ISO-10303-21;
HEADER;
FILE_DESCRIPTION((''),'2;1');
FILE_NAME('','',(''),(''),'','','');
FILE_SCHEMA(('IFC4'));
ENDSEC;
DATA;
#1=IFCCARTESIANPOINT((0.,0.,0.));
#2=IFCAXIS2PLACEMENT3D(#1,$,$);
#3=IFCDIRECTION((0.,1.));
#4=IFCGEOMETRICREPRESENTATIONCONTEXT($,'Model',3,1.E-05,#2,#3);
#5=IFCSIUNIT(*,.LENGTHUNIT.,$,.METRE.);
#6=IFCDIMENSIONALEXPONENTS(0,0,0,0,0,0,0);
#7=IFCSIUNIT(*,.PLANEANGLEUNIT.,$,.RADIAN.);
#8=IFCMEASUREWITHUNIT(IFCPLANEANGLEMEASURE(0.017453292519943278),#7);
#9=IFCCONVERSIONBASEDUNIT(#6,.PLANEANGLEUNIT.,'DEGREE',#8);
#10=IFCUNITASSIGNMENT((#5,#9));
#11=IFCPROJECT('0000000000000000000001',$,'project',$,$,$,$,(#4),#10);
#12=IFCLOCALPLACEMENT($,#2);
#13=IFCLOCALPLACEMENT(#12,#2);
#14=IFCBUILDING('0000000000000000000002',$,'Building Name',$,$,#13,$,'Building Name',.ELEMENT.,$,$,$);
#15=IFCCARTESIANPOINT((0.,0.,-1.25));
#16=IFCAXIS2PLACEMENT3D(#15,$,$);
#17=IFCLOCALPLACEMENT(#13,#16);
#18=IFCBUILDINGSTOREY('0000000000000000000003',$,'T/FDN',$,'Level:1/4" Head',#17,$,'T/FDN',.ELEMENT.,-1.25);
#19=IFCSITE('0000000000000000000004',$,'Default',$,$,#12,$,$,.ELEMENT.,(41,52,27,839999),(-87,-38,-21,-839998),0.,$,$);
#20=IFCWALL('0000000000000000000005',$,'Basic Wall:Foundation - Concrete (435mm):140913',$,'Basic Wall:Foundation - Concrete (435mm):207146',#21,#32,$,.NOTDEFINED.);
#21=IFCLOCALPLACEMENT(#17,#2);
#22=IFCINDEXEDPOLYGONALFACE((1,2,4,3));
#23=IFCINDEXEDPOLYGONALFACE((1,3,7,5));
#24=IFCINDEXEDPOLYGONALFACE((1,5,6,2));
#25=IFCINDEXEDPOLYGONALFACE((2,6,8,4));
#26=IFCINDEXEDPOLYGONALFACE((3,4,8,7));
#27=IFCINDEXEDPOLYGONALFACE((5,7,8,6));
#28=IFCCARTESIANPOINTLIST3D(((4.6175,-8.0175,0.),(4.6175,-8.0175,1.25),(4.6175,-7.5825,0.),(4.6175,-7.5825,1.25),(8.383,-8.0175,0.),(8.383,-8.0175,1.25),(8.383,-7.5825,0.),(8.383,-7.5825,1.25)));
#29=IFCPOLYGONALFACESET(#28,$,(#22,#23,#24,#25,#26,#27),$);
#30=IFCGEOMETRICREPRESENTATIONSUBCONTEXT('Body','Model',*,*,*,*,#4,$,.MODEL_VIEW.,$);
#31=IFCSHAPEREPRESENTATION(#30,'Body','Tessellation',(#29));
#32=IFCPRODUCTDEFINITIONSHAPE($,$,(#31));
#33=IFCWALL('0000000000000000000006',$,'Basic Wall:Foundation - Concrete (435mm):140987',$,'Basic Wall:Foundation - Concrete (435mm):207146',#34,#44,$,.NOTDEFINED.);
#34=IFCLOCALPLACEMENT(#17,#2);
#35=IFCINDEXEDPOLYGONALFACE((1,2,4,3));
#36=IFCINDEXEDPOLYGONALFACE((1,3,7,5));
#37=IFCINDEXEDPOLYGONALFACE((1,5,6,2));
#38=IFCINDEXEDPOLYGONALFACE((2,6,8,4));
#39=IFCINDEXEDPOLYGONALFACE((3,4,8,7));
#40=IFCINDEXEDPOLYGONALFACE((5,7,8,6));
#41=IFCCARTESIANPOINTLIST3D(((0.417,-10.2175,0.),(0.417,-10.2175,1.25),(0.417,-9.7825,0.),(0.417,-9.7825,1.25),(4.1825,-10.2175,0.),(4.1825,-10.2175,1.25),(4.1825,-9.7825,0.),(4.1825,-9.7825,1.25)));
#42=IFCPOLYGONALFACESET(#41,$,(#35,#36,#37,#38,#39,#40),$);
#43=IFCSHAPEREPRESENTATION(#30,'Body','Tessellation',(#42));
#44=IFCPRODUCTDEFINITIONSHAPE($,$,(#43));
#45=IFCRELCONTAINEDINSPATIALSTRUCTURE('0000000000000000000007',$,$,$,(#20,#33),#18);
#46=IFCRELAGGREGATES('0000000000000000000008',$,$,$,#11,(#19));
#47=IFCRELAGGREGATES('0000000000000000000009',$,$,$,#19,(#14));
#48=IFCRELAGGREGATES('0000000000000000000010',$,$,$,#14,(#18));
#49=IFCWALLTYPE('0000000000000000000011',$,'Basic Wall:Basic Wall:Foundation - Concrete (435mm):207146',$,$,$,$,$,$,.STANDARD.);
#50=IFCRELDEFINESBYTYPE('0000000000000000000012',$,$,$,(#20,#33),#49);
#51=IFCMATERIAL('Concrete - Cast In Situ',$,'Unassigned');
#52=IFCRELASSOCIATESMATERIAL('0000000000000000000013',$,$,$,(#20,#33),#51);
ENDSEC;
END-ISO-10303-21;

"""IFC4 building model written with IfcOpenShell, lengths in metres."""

from ifc_helpers import new_model, entity, si_unit, converted_unit, direction, frame, origin, place, context, subcontext, project, spatial, indexed_curve, outline, extrude, material, type_object, element, save


model = new_model("IFC4")

# Units and contexts
model_context = context("Model", 3, precision=1e-05, world=origin(), true_north=direction((0.0, 1.0)))
body_context = subcontext(model_context, "Body", "Model", "MODEL_VIEW")
ifc_project = project(units=[si_unit("LENGTHUNIT", "METRE"), converted_unit("PLANEANGLEUNIT", "DEGREE", entity("IfcPlaneAngleMeasure", 0.017453292519943278), si_unit("PLANEANGLEUNIT", "RADIAN"), dimensions=[0, 0, 0, 0, 0, 0, 0])], contexts=[model_context])

# Site, building, storey
site_placement = place(None, origin())
site = spatial("IfcSite", under=ifc_project, at=site_placement, Name="Default", CompositionType="ELEMENT", RefLatitude=(41, 52, 27, 839999), RefLongitude=(-87, -38, -21, -839998), RefElevation=0.0)
building_placement = place(site_placement, origin())
building = spatial("IfcBuilding", under=site, at=building_placement, Name="Building Name", LongName="Building Name", CompositionType="ELEMENT")
storey_placement = place(building_placement, frame((0.0, 0.0, -1.25)))
storey = spatial("IfcBuildingStorey", under=building, at=storey_placement, Name="T/FDN", ObjectType="Level:1/4\" Head", LongName="T/FDN", CompositionType="ELEMENT", Elevation=-1.25)

# Shared definitions
ifc_material = material(Name="Concrete - Cast In Situ", Category="Unassigned")

# Walls
wall_type_1 = type_object("IfcWallType", Name="Basic Wall:Basic Wall:Foundation - Concrete (435mm):207146", PredefinedType="STANDARD")
wall_1_placement = place(storey_placement, frame((8.383, -7.8, 0.0), z_axis=(0.0, 0.0, 1.0), x_axis=(-1.0, 0.0, 0.0)))
element("IfcWall", 1, at=wall_1_placement, inside=storey, type_object=wall_type_1, material=ifc_material, Name="Basic Wall:Foundation - Concrete (435mm):140913", ObjectType="Basic Wall:Foundation - Concrete (435mm):207146", PredefinedType="NOTDEFINED", context=body_context, shape_type="SweptSolid", body=[
    extrude(outline(indexed_curve([(3.7655, 0.2175), (0.0, 0.2175), (0.0, -0.2175), (3.7655, -0.2175), (3.7655, 0.2175)], self_intersect=False)), origin(), (0.0, 0.0, 1.0), 1.25),
])
wall_2_placement = place(storey_placement, frame((0.417, -10.0, 0.0)))
element("IfcWall", 2, at=wall_2_placement, inside=storey, type_object=wall_type_1, material=ifc_material, Name="Basic Wall:Foundation - Concrete (435mm):140987", ObjectType="Basic Wall:Foundation - Concrete (435mm):207146", PredefinedType="NOTDEFINED", context=body_context, shape_type="SweptSolid", body=[
    extrude(outline(indexed_curve([(3.7655, 0.2175), (0.0, 0.2175), (0.0, -0.2175), (3.7655, -0.2175), (3.7655, 0.2175)], self_intersect=False)), origin(), (0.0, 0.0, 1.0), 1.25),
])

save(model, "model.ifc")
